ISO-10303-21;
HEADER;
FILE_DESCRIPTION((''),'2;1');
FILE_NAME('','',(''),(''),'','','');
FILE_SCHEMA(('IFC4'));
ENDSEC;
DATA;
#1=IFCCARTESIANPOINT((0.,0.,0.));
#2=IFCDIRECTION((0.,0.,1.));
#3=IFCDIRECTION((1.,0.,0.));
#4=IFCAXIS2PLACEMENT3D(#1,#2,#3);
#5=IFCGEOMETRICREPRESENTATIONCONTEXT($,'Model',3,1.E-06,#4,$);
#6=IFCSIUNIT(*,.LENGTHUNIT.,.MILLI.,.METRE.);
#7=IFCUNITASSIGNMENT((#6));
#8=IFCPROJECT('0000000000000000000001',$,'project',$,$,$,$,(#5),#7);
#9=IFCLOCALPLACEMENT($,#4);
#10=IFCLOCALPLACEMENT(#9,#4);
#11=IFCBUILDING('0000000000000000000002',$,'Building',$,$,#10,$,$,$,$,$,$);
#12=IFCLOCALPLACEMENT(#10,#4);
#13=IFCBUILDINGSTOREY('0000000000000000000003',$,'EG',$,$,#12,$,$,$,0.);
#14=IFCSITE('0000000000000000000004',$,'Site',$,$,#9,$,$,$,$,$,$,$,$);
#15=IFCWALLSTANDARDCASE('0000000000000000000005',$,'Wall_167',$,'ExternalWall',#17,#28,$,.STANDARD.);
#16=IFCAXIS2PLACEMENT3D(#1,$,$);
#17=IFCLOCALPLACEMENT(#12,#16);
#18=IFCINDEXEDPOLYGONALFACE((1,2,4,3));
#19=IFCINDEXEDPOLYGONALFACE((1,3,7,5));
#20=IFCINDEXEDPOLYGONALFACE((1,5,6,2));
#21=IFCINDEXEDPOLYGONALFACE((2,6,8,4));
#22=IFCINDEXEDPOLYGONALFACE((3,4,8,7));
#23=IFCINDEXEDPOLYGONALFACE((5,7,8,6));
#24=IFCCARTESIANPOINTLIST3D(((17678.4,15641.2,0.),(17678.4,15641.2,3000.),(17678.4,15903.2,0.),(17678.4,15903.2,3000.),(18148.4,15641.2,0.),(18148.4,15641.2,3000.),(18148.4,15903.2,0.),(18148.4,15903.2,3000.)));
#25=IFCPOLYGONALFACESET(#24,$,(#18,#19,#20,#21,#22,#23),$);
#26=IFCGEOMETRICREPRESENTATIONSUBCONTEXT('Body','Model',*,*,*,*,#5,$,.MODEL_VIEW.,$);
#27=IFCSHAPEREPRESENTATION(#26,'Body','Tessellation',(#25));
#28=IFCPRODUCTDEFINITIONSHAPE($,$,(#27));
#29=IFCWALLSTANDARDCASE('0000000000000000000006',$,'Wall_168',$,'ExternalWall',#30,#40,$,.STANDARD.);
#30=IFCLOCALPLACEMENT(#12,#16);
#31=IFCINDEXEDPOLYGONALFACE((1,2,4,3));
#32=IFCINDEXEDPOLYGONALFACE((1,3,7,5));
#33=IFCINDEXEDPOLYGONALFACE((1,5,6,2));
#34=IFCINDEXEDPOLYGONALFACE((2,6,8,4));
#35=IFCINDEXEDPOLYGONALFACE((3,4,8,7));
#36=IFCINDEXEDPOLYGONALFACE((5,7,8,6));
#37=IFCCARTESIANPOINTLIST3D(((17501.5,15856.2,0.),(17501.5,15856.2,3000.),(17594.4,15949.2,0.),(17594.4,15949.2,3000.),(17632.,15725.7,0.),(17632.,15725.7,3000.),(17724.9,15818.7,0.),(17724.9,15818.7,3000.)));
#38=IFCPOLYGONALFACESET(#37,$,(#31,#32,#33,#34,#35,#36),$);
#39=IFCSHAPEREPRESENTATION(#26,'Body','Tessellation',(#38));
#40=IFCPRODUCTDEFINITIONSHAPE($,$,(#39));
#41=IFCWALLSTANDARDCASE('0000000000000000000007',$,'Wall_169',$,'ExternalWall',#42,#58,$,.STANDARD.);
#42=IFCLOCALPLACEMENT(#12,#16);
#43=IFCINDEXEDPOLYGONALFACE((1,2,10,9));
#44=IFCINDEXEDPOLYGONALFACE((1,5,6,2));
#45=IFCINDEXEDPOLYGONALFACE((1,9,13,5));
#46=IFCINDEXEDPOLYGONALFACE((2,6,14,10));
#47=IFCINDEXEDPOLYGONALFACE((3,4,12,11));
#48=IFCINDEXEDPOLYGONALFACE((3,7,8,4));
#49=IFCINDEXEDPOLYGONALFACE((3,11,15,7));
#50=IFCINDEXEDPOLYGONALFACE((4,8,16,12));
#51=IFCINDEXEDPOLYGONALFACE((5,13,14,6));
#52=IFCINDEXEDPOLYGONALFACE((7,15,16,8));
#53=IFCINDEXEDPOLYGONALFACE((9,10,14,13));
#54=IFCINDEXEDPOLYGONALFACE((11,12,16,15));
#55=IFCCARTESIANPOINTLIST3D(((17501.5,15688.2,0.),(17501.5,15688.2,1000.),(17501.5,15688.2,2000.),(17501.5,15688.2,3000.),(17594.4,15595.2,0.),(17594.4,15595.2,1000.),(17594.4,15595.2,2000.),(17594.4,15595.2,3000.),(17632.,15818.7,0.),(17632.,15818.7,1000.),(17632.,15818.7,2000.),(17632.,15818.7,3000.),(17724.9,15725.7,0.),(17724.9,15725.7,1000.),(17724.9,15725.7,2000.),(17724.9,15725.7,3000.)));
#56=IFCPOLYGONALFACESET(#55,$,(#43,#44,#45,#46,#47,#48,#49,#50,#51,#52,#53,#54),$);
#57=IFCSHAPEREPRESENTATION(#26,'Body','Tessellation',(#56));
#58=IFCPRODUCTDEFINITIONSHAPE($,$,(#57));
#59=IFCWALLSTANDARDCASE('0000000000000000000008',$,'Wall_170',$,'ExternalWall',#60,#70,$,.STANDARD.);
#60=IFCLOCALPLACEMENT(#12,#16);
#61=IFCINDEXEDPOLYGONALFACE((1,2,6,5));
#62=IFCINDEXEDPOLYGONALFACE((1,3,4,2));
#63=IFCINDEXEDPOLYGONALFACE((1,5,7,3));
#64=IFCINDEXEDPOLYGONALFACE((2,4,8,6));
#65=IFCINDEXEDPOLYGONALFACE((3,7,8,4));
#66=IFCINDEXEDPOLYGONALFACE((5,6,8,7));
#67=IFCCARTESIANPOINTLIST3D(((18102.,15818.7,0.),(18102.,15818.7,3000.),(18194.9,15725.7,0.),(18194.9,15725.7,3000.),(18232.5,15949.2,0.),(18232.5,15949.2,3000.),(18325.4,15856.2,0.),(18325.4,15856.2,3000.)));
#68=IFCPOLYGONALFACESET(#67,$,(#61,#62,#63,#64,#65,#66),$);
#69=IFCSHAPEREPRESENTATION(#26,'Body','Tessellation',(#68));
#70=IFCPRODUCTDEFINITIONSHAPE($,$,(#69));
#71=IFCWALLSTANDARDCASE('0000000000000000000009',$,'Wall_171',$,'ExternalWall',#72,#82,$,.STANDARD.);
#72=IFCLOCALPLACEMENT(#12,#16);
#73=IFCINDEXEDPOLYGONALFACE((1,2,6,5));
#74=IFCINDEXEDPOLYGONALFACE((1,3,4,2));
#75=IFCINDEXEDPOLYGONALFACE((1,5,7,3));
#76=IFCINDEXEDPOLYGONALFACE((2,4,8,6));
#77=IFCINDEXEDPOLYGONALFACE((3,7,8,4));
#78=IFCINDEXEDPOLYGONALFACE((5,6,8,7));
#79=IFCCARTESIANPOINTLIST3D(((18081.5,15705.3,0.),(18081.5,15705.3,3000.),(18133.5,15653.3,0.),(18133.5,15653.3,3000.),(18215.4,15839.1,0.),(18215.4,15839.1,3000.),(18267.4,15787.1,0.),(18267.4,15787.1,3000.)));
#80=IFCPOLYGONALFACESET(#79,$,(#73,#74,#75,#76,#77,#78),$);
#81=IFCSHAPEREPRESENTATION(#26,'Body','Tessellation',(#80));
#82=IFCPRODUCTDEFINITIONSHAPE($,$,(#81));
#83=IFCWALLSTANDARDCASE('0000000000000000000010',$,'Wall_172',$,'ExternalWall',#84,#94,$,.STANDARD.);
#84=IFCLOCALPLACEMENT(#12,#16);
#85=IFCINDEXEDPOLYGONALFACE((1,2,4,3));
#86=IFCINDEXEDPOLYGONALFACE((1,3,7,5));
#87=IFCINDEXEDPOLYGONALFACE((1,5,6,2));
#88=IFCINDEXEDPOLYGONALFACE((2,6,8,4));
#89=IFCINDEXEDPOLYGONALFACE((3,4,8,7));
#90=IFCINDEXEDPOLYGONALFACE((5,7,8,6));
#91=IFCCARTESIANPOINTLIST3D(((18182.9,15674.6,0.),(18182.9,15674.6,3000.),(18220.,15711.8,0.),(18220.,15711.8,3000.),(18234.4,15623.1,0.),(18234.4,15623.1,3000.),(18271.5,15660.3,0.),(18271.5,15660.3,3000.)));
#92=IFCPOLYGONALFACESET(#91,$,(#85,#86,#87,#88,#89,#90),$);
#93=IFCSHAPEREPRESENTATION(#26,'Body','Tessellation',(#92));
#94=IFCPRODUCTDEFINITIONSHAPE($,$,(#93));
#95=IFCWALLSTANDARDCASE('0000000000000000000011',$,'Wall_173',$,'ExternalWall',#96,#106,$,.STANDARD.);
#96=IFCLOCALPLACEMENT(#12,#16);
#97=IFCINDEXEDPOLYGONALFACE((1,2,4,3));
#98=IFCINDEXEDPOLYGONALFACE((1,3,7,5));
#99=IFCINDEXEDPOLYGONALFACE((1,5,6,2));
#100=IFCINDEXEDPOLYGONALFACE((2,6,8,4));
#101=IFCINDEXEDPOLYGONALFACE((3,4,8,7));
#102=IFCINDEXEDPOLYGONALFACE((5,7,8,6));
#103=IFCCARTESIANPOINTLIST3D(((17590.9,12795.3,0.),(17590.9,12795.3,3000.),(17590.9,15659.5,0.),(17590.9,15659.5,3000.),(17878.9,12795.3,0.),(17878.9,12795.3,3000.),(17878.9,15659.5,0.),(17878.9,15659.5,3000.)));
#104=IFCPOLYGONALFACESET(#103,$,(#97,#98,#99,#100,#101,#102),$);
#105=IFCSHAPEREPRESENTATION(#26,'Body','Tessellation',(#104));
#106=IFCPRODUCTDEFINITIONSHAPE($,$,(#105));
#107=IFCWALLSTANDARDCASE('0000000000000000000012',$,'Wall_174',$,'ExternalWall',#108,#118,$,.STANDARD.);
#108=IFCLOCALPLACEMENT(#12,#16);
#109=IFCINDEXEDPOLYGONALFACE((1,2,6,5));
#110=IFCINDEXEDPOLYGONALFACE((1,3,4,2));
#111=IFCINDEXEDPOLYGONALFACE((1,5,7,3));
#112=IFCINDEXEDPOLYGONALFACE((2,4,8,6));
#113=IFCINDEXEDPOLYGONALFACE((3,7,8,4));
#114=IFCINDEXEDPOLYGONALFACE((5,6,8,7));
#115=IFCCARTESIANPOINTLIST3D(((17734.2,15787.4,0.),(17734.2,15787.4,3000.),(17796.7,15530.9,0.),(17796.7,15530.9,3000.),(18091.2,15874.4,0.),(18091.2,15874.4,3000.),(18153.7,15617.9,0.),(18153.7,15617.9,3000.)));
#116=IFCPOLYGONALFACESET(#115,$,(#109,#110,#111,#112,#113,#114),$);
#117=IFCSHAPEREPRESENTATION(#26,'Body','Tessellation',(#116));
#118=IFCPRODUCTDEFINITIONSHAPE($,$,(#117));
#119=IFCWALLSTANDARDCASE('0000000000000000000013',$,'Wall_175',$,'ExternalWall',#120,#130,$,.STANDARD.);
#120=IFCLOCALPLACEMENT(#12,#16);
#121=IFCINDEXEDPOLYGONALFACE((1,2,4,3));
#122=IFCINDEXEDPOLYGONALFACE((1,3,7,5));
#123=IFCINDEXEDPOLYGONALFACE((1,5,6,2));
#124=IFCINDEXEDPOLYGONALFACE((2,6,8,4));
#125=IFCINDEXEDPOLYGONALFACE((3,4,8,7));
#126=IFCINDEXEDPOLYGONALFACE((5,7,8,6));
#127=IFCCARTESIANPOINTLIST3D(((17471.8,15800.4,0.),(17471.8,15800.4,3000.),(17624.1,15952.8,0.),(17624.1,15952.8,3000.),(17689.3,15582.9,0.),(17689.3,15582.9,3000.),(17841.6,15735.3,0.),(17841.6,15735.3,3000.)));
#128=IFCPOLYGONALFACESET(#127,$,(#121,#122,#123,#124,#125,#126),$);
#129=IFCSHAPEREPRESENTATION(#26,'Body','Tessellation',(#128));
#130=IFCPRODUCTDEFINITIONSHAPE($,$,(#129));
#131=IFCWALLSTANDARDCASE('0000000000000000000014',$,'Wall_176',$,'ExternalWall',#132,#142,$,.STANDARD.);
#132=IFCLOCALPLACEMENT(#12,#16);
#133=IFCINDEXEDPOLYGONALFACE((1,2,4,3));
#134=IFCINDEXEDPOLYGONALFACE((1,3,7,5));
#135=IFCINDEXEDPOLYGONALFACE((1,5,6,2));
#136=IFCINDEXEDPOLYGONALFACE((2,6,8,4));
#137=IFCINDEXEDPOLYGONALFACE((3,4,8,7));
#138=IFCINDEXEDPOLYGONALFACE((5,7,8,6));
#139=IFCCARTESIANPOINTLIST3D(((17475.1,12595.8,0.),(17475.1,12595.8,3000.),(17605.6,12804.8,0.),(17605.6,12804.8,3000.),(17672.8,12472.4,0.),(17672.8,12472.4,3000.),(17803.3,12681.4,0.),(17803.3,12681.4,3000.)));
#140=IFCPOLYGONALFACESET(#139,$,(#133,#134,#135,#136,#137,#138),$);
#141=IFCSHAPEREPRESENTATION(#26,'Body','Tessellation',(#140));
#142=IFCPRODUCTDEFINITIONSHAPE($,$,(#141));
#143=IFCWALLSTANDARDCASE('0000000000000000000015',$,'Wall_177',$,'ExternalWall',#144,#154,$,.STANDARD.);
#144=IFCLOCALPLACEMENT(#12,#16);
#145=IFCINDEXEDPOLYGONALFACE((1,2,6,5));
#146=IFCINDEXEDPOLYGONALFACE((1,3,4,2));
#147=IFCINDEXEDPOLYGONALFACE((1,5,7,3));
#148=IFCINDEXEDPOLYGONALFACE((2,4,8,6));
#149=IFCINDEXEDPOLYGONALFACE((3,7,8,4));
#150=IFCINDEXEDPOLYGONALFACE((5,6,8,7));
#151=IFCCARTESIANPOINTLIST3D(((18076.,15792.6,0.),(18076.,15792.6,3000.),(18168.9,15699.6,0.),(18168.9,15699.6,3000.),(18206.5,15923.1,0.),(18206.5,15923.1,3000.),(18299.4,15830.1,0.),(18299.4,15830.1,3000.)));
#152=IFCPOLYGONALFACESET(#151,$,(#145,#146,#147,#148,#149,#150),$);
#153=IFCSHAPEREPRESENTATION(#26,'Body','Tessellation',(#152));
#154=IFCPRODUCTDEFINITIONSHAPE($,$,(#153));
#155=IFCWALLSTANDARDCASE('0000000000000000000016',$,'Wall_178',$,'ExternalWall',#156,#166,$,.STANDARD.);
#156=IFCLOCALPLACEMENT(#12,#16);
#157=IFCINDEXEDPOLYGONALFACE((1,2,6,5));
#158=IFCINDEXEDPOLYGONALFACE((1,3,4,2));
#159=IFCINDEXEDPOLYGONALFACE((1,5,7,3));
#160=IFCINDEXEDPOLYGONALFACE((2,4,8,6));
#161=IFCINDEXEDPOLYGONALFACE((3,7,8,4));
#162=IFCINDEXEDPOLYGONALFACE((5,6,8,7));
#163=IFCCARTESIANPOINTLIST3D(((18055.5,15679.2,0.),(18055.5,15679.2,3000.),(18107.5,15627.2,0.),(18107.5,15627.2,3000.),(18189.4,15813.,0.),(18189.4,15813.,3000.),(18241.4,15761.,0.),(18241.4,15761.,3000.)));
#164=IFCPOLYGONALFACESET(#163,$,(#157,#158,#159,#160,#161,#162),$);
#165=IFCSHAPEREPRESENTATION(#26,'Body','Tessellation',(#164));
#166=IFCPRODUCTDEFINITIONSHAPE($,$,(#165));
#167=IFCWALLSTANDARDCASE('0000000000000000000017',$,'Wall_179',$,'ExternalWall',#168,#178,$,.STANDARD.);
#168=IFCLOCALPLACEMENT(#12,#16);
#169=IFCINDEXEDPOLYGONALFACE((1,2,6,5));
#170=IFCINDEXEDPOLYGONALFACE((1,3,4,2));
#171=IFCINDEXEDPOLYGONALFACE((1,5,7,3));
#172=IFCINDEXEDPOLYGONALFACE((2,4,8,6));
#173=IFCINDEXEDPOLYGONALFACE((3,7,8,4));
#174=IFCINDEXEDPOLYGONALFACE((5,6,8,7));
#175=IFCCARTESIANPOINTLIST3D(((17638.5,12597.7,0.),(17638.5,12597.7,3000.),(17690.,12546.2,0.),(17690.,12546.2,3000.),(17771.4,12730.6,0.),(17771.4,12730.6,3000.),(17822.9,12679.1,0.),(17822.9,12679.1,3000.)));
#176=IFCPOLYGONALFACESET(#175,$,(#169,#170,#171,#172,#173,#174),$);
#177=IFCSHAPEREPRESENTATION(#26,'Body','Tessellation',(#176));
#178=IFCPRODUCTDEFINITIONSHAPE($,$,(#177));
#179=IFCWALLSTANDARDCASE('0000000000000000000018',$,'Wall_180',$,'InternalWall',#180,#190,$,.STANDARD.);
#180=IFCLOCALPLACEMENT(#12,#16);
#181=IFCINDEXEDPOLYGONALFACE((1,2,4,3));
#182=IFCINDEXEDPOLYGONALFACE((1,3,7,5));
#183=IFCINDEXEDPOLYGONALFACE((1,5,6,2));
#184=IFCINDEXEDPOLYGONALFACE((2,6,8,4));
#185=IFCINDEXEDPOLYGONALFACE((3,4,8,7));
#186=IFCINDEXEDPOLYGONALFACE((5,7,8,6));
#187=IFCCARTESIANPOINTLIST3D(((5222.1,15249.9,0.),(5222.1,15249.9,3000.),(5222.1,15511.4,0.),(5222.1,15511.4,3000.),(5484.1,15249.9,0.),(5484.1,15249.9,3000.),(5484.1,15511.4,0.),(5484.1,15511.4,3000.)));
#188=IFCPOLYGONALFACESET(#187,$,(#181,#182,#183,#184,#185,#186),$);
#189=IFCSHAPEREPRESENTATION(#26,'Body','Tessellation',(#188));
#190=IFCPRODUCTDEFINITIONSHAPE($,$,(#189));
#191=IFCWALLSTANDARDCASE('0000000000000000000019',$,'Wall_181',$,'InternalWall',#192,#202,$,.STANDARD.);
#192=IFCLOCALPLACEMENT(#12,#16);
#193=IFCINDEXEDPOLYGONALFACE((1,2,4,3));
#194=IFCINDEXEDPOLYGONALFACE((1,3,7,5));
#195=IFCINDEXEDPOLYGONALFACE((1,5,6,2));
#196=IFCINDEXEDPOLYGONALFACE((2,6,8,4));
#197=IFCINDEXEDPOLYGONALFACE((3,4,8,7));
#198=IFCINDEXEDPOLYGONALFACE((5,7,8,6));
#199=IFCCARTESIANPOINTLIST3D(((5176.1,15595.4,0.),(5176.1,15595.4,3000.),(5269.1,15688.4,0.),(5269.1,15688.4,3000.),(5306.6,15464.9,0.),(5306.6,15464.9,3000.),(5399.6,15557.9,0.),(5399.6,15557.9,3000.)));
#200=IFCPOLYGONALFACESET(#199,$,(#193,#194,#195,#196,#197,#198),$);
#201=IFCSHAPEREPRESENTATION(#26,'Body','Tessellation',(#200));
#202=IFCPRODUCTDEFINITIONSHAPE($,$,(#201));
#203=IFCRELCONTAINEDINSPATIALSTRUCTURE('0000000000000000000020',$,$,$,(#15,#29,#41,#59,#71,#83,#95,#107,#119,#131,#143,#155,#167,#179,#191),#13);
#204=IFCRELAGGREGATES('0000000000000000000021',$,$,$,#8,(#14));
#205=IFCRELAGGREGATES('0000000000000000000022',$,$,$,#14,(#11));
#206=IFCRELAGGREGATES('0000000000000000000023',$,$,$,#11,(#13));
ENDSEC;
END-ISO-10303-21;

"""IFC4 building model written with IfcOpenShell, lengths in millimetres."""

from ifc_helpers import new_model, si_unit, frame, origin_with_axes, place, context, subcontext, project, spatial, rectangle, extrude, element, save


model = new_model("IFC4")

# Units and contexts
model_context = context("Model", 3, precision=1e-06, world=origin_with_axes())
body_context = subcontext(model_context, "Body", "Model", "MODEL_VIEW")
ifc_project = project(units=[si_unit("LENGTHUNIT", "METRE", prefix="MILLI")], contexts=[model_context])

# Site, building, storey
site_placement = place(None, origin_with_axes())
site = spatial("IfcSite", under=ifc_project, at=site_placement, Name="Site")
building_placement = place(site_placement, origin_with_axes())
building = spatial("IfcBuilding", under=site, at=building_placement, Name="Building")
storey_placement = place(building_placement, origin_with_axes())
storey = spatial("IfcBuildingStorey", under=building, at=storey_placement, Name="EG", Elevation=0.0)

# Walls
wall_1_placement = place(storey_placement, origin_with_axes())
element("IfcWallStandardCase", 1, at=wall_1_placement, inside=storey, Name="Wall_167", ObjectType="ExternalWall", PredefinedType="STANDARD", context=body_context, shape_type="SweptSolid", body=[
    extrude(rectangle(XDim=470.0, YDim=262.0), frame((17913.4, 15772.2, 0.0), z_axis=(0.0, 0.0, 1.0), x_axis=(1.0, 0.0, 0.0)), (0.0, 0.0, 1.0), 3000.0),
])
wall_2_placement = place(storey_placement, origin_with_axes())
element("IfcWallStandardCase", 2, at=wall_2_placement, inside=storey, Name="Wall_168", ObjectType="ExternalWall", PredefinedType="STANDARD", context=body_context, shape_type="SweptSolid", body=[
    extrude(rectangle(XDim=184.6, YDim=131.5), frame((17613.2, 15837.4, 0.0), z_axis=(0.0, 0.0, 1.0), x_axis=(0.707107, -0.707107, 0.0)), (0.0, 0.0, 1.0), 3000.0),
])

# Wall, opening
wall_3_placement = place(storey_placement, origin_with_axes())
wall_3 = element("IfcWallStandardCase", 3, at=wall_3_placement, inside=storey, Name="Wall_169", ObjectType="ExternalWall", PredefinedType="STANDARD", context=body_context, shape_type="SweptSolid", body=[
    extrude(rectangle(XDim=184.6, YDim=131.5), frame((17613.2, 15706.9, 0.0), z_axis=(0.0, 0.0, 1.0), x_axis=(-0.707107, -0.707107, 0.0)), (0.0, 0.0, 1.0), 3000.0),
])
opening_1_placement = place(wall_3_placement, origin_with_axes())
element("IfcOpeningElement", 4, at=opening_1_placement, inside=storey, cuts=wall_3, context=body_context, shape_type="SweptSolid", body=[
    extrude(rectangle(XDim=600.0, YDim=131.5), frame((17587.1, 15680.9, 1000.0), z_axis=(0.0, 0.0, 1.0), x_axis=(-0.707107, -0.707107, 0.0)), (0.0, 0.0, 1.0), 1000.0),
])

# Walls
wall_4_placement = place(storey_placement, origin_with_axes())
element("IfcWallStandardCase", 5, at=wall_4_placement, inside=storey, Name="Wall_170", ObjectType="ExternalWall", PredefinedType="STANDARD", context=body_context, shape_type="SweptSolid", body=[
    extrude(rectangle(XDim=184.6, YDim=131.5), frame((18213.7, 15837.4, 0.0), z_axis=(0.0, 0.0, 1.0), x_axis=(0.707107, 0.707107, 0.0)), (0.0, 0.0, 1.0), 3000.0),
])
wall_5_placement = place(storey_placement, origin_with_axes())
element("IfcWallStandardCase", 6, at=wall_5_placement, inside=storey, Name="Wall_171", ObjectType="ExternalWall", PredefinedType="STANDARD", context=body_context, shape_type="SweptSolid", body=[
    extrude(rectangle(XDim=73.5, YDim=189.2), frame((18174.4, 15746.2, 0.0), z_axis=(0.0, 0.0, 1.0), x_axis=(0.707107, -0.707107, 0.0)), (0.0, 0.0, 1.0), 3000.0),
])
wall_6_placement = place(storey_placement, origin_with_axes())
element("IfcWallStandardCase", 7, at=wall_6_placement, inside=storey, Name="Wall_172", ObjectType="ExternalWall", PredefinedType="STANDARD", context=body_context, shape_type="SweptSolid", body=[
    extrude(rectangle(XDim=72.8, YDim=52.5), frame((18227.2, 15667.4, 0.0), z_axis=(0.0, 0.0, 1.0), x_axis=(0.707107, -0.707107, 0.0)), (0.0, 0.0, 1.0), 3000.0),
])
wall_7_placement = place(storey_placement, origin_with_axes())
element("IfcWallStandardCase", 8, at=wall_7_placement, inside=storey, Name="Wall_173", ObjectType="ExternalWall", PredefinedType="STANDARD", context=body_context, shape_type="SweptSolid", body=[
    extrude(rectangle(XDim=2864.1, YDim=288.0), frame((17734.9, 14227.4, 0.0), z_axis=(0.0, 0.0, 1.0), x_axis=(0.0, -1.0, 0.0)), (0.0, 0.0, 1.0), 3000.0),
])
wall_8_placement = place(storey_placement, origin_with_axes())
element("IfcWallStandardCase", 9, at=wall_8_placement, inside=storey, Name="Wall_174", ObjectType="ExternalWall", PredefinedType="STANDARD", context=body_context, shape_type="SweptSolid", body=[
    extrude(rectangle(XDim=367.4, YDim=264.0), frame((17943.9, 15702.6, 0.0), z_axis=(0.0, 0.0, 1.0), x_axis=(-0.971566, -0.236768, 0.0)), (0.0, 0.0, 1.0), 3000.0),
])
wall_9_placement = place(storey_placement, origin_with_axes())
element("IfcWallStandardCase", 10, at=wall_9_placement, inside=storey, Name="Wall_175", ObjectType="ExternalWall", PredefinedType="STANDARD", context=body_context, shape_type="SweptSolid", body=[
    extrude(rectangle(XDim=307.6, YDim=215.5), frame((17656.7, 15767.9, 0.0), z_axis=(0.0, 0.0, 1.0), x_axis=(-0.707107, 0.707107, 0.0)), (0.0, 0.0, 1.0), 3000.0),
])
wall_10_placement = place(storey_placement, origin_with_axes())
element("IfcWallStandardCase", 11, at=wall_10_placement, inside=storey, Name="Wall_176", ObjectType="ExternalWall", PredefinedType="STANDARD", context=body_context, shape_type="SweptSolid", body=[
    extrude(rectangle(XDim=246.4, YDim=233.0), frame((17639.2, 12638.6, 0.0), z_axis=(0.0, 0.0, 1.0), x_axis=(-0.529634, -0.848226, 0.0)), (0.0, 0.0, 1.0), 3000.0),
])
wall_11_placement = place(storey_placement, origin_with_axes())
element("IfcWallStandardCase", 12, at=wall_11_placement, inside=storey, Name="Wall_177", ObjectType="ExternalWall", PredefinedType="STANDARD", context=body_context, shape_type="SweptSolid", body=[
    extrude(rectangle(XDim=184.6, YDim=131.5), frame((18187.7, 15811.4, 0.0), z_axis=(0.0, 0.0, 1.0), x_axis=(0.707107, 0.707107, 0.0)), (0.0, 0.0, 1.0), 3000.0),
])
wall_12_placement = place(storey_placement, origin_with_axes())
element("IfcWallStandardCase", 13, at=wall_12_placement, inside=storey, Name="Wall_178", ObjectType="ExternalWall", PredefinedType="STANDARD", context=body_context, shape_type="SweptSolid", body=[
    extrude(rectangle(XDim=73.5, YDim=189.2), frame((18148.4, 15720.1, 0.0), z_axis=(0.0, 0.0, 1.0), x_axis=(0.707107, -0.707107, 0.0)), (0.0, 0.0, 1.0), 3000.0),
])
wall_13_placement = place(storey_placement, origin_with_axes())
element("IfcWallStandardCase", 14, at=wall_13_placement, inside=storey, Name="Wall_179", ObjectType="ExternalWall", PredefinedType="STANDARD", context=body_context, shape_type="SweptSolid", body=[
    extrude(rectangle(XDim=72.8, YDim=187.9), frame((17730.7, 12638.4, 0.0), z_axis=(0.0, 0.0, 1.0), x_axis=(0.707107, -0.707107, 0.0)), (0.0, 0.0, 1.0), 3000.0),
])
wall_14_placement = place(storey_placement, origin_with_axes())
element("IfcWallStandardCase", 15, at=wall_14_placement, inside=storey, Name="Wall_180", ObjectType="InternalWall", PredefinedType="STANDARD", context=body_context, shape_type="SweptSolid", body=[
    extrude(rectangle(XDim=261.5, YDim=262.0), frame((5353.1, 15380.7, 0.0), z_axis=(0.0, 0.0, 1.0), x_axis=(0.0, -1.0, 0.0)), (0.0, 0.0, 1.0), 3000.0),
])
wall_15_placement = place(storey_placement, origin_with_axes())
element("IfcWallStandardCase", 16, at=wall_15_placement, inside=storey, Name="Wall_181", ObjectType="InternalWall", PredefinedType="STANDARD", context=body_context, shape_type="SweptSolid", body=[
    extrude(rectangle(XDim=184.6, YDim=131.5), frame((5287.9, 15576.7, 0.0), z_axis=(0.0, 0.0, 1.0), x_axis=(-0.707107, 0.707107, 0.0)), (0.0, 0.0, 1.0), 3000.0),
])

save(model, "model.ifc")
